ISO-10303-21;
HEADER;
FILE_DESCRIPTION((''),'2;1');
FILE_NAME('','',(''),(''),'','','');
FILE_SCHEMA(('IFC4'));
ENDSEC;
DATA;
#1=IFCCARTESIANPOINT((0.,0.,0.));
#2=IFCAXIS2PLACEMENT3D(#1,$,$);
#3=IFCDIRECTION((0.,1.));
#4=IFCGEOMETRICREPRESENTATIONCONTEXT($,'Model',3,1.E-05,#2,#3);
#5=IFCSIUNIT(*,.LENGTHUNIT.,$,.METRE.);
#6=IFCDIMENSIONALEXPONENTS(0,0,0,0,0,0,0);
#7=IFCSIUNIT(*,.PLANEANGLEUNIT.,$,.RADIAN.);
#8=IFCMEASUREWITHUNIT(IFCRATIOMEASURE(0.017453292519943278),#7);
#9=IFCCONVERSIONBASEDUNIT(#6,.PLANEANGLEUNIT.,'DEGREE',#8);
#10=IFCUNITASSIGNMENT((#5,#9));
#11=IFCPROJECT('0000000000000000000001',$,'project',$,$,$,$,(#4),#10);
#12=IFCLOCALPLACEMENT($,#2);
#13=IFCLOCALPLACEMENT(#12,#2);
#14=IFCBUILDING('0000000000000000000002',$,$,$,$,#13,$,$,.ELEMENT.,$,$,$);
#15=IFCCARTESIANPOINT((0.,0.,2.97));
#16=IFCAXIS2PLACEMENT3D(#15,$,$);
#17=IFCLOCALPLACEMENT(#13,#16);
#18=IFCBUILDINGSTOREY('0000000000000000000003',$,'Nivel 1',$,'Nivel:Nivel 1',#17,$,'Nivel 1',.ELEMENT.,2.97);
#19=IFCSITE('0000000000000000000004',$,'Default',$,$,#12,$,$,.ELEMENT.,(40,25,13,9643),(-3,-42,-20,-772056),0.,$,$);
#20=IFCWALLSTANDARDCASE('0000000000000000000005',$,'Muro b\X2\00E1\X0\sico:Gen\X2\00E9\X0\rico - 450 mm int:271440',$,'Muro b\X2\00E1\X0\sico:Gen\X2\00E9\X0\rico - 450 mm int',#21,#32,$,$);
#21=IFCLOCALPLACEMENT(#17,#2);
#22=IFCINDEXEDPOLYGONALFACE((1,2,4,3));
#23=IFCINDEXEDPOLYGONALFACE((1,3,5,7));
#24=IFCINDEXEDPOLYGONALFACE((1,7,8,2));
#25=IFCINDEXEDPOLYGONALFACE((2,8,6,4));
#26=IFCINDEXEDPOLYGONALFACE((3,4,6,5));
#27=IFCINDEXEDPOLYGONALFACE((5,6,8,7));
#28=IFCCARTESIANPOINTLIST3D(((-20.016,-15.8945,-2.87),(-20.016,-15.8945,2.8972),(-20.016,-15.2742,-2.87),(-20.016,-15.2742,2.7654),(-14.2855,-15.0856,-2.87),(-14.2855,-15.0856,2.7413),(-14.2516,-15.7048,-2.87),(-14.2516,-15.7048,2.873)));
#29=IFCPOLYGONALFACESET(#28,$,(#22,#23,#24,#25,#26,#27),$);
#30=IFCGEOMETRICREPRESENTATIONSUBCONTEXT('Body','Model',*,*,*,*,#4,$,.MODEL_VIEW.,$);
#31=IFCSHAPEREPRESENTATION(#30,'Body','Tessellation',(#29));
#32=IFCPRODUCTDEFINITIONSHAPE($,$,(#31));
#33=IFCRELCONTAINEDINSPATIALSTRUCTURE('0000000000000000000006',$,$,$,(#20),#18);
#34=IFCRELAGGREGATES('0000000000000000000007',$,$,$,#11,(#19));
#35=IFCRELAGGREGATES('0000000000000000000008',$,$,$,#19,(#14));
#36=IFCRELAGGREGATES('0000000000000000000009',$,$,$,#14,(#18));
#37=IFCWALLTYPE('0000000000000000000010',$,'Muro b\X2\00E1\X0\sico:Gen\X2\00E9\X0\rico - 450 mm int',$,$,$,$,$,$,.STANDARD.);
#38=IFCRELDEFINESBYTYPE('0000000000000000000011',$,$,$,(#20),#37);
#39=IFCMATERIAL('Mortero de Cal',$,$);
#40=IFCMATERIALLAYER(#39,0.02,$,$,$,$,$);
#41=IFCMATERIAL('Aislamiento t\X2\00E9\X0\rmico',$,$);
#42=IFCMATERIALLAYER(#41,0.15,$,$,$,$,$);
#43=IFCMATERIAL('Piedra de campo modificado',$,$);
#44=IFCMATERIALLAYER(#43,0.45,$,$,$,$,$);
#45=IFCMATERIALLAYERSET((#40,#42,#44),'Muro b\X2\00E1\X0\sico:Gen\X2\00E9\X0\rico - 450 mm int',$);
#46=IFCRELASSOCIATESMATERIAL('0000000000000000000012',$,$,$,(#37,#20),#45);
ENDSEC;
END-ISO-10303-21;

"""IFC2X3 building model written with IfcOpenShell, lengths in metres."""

from ifc_helpers import new_model, entity, si_unit, converted_unit, direction, frame, origin, place, context, subcontext, project, spatial, polyline, outline, extrude, clip, bounded_halfspace, material, layer, layer_set, layer_usage, type_object, element, save


model = new_model("IFC2X3")

# Units and contexts
model_context = context("Model", 3, precision=1e-05, world=origin(), true_north=direction((0.0, 1.0)))
body_context = subcontext(model_context, "Body", "Model", "MODEL_VIEW")
ifc_project = project(units=[si_unit("LENGTHUNIT", "METRE"), converted_unit("PLANEANGLEUNIT", "DEGREE", entity("IfcRatioMeasure", 0.017453292519943278), si_unit("PLANEANGLEUNIT", "RADIAN"), dimensions=[0, 0, 0, 0, 0, 0, 0])], contexts=[model_context])

# Site, building, storey
site_placement = place(None, origin())
site = spatial("IfcSite", under=ifc_project, at=site_placement, Name="Default", CompositionType="ELEMENT", RefLatitude=(40, 25, 13, 9643), RefLongitude=(-3, -42, -20, -772056), RefElevation=0.0)
building_placement = place(site_placement, origin())
building = spatial("IfcBuilding", under=site, at=building_placement, CompositionType="ELEMENT")
storey_placement = place(building_placement, frame((0.0, 0.0, 2.97)))
storey = spatial("IfcBuildingStorey", under=building, at=storey_placement, Name="Nivel 1", ObjectType="Nivel:Nivel 1", LongName="Nivel 1", CompositionType="ELEMENT", Elevation=2.97)

# Wall
ifc_material_1 = material(Name="Mortero de Cal")
ifc_layer_1 = layer(ifc_material_1, 0.02)
ifc_material_2 = material(Name="Aislamiento térmico")
ifc_layer_2 = layer(ifc_material_2, 0.15)
ifc_material_3 = material(Name="Piedra de campo modificado")
ifc_layer_3 = layer(ifc_material_3, 0.45)
ifc_layer_set_1 = layer_set([ifc_layer_1, ifc_layer_2, ifc_layer_3], Name="Muro básico:Genérico - 450 mm int")
ifc_layer_usage_1 = layer_usage(ifc_layer_set_1, "AXIS2", "NEGATIVE", 0.31)
wall_type = type_object("IfcWallType", Name="Muro básico:Genérico - 450 mm int", PredefinedType="STANDARD", material=ifc_layer_set_1)
wall_placement = place(storey_placement, frame((-20.0262, -15.5847, -2.87), z_axis=(0.0, 0.0, 1.0), x_axis=(0.999459, 0.032881, 0.0)))
element("IfcWallStandardCase", 1, at=wall_placement, inside=storey, type_object=wall_type, material=ifc_layer_usage_1, Name="Muro básico:Genérico - 450 mm int:271440", ObjectType="Muro básico:Genérico - 450 mm int", context=body_context, shape_type="Clipping", body=[
    clip(extrude(outline(polyline([(5.7675, -0.31), (5.754, 0.31), (0.0204, 0.31), (0.0, -0.31), (5.7675, -0.31)])), origin(), (0.0, 0.0, 1.0), 5.7672), bounded_halfspace(frame((0.0, -0.31, 5.7672), z_axis=(0.004115, 0.207871, 0.978148), x_axis=(-0.999804, 0.019794, 0.0)), False, frame((0.0, -0.31, 5.7672)), polyline([(0.0, 0.0), (5.7675, 0.0), (5.754, 0.62), (0.0204, 0.62), (0.0, 0.0)]))),
])

save(model, "model.ifc")
